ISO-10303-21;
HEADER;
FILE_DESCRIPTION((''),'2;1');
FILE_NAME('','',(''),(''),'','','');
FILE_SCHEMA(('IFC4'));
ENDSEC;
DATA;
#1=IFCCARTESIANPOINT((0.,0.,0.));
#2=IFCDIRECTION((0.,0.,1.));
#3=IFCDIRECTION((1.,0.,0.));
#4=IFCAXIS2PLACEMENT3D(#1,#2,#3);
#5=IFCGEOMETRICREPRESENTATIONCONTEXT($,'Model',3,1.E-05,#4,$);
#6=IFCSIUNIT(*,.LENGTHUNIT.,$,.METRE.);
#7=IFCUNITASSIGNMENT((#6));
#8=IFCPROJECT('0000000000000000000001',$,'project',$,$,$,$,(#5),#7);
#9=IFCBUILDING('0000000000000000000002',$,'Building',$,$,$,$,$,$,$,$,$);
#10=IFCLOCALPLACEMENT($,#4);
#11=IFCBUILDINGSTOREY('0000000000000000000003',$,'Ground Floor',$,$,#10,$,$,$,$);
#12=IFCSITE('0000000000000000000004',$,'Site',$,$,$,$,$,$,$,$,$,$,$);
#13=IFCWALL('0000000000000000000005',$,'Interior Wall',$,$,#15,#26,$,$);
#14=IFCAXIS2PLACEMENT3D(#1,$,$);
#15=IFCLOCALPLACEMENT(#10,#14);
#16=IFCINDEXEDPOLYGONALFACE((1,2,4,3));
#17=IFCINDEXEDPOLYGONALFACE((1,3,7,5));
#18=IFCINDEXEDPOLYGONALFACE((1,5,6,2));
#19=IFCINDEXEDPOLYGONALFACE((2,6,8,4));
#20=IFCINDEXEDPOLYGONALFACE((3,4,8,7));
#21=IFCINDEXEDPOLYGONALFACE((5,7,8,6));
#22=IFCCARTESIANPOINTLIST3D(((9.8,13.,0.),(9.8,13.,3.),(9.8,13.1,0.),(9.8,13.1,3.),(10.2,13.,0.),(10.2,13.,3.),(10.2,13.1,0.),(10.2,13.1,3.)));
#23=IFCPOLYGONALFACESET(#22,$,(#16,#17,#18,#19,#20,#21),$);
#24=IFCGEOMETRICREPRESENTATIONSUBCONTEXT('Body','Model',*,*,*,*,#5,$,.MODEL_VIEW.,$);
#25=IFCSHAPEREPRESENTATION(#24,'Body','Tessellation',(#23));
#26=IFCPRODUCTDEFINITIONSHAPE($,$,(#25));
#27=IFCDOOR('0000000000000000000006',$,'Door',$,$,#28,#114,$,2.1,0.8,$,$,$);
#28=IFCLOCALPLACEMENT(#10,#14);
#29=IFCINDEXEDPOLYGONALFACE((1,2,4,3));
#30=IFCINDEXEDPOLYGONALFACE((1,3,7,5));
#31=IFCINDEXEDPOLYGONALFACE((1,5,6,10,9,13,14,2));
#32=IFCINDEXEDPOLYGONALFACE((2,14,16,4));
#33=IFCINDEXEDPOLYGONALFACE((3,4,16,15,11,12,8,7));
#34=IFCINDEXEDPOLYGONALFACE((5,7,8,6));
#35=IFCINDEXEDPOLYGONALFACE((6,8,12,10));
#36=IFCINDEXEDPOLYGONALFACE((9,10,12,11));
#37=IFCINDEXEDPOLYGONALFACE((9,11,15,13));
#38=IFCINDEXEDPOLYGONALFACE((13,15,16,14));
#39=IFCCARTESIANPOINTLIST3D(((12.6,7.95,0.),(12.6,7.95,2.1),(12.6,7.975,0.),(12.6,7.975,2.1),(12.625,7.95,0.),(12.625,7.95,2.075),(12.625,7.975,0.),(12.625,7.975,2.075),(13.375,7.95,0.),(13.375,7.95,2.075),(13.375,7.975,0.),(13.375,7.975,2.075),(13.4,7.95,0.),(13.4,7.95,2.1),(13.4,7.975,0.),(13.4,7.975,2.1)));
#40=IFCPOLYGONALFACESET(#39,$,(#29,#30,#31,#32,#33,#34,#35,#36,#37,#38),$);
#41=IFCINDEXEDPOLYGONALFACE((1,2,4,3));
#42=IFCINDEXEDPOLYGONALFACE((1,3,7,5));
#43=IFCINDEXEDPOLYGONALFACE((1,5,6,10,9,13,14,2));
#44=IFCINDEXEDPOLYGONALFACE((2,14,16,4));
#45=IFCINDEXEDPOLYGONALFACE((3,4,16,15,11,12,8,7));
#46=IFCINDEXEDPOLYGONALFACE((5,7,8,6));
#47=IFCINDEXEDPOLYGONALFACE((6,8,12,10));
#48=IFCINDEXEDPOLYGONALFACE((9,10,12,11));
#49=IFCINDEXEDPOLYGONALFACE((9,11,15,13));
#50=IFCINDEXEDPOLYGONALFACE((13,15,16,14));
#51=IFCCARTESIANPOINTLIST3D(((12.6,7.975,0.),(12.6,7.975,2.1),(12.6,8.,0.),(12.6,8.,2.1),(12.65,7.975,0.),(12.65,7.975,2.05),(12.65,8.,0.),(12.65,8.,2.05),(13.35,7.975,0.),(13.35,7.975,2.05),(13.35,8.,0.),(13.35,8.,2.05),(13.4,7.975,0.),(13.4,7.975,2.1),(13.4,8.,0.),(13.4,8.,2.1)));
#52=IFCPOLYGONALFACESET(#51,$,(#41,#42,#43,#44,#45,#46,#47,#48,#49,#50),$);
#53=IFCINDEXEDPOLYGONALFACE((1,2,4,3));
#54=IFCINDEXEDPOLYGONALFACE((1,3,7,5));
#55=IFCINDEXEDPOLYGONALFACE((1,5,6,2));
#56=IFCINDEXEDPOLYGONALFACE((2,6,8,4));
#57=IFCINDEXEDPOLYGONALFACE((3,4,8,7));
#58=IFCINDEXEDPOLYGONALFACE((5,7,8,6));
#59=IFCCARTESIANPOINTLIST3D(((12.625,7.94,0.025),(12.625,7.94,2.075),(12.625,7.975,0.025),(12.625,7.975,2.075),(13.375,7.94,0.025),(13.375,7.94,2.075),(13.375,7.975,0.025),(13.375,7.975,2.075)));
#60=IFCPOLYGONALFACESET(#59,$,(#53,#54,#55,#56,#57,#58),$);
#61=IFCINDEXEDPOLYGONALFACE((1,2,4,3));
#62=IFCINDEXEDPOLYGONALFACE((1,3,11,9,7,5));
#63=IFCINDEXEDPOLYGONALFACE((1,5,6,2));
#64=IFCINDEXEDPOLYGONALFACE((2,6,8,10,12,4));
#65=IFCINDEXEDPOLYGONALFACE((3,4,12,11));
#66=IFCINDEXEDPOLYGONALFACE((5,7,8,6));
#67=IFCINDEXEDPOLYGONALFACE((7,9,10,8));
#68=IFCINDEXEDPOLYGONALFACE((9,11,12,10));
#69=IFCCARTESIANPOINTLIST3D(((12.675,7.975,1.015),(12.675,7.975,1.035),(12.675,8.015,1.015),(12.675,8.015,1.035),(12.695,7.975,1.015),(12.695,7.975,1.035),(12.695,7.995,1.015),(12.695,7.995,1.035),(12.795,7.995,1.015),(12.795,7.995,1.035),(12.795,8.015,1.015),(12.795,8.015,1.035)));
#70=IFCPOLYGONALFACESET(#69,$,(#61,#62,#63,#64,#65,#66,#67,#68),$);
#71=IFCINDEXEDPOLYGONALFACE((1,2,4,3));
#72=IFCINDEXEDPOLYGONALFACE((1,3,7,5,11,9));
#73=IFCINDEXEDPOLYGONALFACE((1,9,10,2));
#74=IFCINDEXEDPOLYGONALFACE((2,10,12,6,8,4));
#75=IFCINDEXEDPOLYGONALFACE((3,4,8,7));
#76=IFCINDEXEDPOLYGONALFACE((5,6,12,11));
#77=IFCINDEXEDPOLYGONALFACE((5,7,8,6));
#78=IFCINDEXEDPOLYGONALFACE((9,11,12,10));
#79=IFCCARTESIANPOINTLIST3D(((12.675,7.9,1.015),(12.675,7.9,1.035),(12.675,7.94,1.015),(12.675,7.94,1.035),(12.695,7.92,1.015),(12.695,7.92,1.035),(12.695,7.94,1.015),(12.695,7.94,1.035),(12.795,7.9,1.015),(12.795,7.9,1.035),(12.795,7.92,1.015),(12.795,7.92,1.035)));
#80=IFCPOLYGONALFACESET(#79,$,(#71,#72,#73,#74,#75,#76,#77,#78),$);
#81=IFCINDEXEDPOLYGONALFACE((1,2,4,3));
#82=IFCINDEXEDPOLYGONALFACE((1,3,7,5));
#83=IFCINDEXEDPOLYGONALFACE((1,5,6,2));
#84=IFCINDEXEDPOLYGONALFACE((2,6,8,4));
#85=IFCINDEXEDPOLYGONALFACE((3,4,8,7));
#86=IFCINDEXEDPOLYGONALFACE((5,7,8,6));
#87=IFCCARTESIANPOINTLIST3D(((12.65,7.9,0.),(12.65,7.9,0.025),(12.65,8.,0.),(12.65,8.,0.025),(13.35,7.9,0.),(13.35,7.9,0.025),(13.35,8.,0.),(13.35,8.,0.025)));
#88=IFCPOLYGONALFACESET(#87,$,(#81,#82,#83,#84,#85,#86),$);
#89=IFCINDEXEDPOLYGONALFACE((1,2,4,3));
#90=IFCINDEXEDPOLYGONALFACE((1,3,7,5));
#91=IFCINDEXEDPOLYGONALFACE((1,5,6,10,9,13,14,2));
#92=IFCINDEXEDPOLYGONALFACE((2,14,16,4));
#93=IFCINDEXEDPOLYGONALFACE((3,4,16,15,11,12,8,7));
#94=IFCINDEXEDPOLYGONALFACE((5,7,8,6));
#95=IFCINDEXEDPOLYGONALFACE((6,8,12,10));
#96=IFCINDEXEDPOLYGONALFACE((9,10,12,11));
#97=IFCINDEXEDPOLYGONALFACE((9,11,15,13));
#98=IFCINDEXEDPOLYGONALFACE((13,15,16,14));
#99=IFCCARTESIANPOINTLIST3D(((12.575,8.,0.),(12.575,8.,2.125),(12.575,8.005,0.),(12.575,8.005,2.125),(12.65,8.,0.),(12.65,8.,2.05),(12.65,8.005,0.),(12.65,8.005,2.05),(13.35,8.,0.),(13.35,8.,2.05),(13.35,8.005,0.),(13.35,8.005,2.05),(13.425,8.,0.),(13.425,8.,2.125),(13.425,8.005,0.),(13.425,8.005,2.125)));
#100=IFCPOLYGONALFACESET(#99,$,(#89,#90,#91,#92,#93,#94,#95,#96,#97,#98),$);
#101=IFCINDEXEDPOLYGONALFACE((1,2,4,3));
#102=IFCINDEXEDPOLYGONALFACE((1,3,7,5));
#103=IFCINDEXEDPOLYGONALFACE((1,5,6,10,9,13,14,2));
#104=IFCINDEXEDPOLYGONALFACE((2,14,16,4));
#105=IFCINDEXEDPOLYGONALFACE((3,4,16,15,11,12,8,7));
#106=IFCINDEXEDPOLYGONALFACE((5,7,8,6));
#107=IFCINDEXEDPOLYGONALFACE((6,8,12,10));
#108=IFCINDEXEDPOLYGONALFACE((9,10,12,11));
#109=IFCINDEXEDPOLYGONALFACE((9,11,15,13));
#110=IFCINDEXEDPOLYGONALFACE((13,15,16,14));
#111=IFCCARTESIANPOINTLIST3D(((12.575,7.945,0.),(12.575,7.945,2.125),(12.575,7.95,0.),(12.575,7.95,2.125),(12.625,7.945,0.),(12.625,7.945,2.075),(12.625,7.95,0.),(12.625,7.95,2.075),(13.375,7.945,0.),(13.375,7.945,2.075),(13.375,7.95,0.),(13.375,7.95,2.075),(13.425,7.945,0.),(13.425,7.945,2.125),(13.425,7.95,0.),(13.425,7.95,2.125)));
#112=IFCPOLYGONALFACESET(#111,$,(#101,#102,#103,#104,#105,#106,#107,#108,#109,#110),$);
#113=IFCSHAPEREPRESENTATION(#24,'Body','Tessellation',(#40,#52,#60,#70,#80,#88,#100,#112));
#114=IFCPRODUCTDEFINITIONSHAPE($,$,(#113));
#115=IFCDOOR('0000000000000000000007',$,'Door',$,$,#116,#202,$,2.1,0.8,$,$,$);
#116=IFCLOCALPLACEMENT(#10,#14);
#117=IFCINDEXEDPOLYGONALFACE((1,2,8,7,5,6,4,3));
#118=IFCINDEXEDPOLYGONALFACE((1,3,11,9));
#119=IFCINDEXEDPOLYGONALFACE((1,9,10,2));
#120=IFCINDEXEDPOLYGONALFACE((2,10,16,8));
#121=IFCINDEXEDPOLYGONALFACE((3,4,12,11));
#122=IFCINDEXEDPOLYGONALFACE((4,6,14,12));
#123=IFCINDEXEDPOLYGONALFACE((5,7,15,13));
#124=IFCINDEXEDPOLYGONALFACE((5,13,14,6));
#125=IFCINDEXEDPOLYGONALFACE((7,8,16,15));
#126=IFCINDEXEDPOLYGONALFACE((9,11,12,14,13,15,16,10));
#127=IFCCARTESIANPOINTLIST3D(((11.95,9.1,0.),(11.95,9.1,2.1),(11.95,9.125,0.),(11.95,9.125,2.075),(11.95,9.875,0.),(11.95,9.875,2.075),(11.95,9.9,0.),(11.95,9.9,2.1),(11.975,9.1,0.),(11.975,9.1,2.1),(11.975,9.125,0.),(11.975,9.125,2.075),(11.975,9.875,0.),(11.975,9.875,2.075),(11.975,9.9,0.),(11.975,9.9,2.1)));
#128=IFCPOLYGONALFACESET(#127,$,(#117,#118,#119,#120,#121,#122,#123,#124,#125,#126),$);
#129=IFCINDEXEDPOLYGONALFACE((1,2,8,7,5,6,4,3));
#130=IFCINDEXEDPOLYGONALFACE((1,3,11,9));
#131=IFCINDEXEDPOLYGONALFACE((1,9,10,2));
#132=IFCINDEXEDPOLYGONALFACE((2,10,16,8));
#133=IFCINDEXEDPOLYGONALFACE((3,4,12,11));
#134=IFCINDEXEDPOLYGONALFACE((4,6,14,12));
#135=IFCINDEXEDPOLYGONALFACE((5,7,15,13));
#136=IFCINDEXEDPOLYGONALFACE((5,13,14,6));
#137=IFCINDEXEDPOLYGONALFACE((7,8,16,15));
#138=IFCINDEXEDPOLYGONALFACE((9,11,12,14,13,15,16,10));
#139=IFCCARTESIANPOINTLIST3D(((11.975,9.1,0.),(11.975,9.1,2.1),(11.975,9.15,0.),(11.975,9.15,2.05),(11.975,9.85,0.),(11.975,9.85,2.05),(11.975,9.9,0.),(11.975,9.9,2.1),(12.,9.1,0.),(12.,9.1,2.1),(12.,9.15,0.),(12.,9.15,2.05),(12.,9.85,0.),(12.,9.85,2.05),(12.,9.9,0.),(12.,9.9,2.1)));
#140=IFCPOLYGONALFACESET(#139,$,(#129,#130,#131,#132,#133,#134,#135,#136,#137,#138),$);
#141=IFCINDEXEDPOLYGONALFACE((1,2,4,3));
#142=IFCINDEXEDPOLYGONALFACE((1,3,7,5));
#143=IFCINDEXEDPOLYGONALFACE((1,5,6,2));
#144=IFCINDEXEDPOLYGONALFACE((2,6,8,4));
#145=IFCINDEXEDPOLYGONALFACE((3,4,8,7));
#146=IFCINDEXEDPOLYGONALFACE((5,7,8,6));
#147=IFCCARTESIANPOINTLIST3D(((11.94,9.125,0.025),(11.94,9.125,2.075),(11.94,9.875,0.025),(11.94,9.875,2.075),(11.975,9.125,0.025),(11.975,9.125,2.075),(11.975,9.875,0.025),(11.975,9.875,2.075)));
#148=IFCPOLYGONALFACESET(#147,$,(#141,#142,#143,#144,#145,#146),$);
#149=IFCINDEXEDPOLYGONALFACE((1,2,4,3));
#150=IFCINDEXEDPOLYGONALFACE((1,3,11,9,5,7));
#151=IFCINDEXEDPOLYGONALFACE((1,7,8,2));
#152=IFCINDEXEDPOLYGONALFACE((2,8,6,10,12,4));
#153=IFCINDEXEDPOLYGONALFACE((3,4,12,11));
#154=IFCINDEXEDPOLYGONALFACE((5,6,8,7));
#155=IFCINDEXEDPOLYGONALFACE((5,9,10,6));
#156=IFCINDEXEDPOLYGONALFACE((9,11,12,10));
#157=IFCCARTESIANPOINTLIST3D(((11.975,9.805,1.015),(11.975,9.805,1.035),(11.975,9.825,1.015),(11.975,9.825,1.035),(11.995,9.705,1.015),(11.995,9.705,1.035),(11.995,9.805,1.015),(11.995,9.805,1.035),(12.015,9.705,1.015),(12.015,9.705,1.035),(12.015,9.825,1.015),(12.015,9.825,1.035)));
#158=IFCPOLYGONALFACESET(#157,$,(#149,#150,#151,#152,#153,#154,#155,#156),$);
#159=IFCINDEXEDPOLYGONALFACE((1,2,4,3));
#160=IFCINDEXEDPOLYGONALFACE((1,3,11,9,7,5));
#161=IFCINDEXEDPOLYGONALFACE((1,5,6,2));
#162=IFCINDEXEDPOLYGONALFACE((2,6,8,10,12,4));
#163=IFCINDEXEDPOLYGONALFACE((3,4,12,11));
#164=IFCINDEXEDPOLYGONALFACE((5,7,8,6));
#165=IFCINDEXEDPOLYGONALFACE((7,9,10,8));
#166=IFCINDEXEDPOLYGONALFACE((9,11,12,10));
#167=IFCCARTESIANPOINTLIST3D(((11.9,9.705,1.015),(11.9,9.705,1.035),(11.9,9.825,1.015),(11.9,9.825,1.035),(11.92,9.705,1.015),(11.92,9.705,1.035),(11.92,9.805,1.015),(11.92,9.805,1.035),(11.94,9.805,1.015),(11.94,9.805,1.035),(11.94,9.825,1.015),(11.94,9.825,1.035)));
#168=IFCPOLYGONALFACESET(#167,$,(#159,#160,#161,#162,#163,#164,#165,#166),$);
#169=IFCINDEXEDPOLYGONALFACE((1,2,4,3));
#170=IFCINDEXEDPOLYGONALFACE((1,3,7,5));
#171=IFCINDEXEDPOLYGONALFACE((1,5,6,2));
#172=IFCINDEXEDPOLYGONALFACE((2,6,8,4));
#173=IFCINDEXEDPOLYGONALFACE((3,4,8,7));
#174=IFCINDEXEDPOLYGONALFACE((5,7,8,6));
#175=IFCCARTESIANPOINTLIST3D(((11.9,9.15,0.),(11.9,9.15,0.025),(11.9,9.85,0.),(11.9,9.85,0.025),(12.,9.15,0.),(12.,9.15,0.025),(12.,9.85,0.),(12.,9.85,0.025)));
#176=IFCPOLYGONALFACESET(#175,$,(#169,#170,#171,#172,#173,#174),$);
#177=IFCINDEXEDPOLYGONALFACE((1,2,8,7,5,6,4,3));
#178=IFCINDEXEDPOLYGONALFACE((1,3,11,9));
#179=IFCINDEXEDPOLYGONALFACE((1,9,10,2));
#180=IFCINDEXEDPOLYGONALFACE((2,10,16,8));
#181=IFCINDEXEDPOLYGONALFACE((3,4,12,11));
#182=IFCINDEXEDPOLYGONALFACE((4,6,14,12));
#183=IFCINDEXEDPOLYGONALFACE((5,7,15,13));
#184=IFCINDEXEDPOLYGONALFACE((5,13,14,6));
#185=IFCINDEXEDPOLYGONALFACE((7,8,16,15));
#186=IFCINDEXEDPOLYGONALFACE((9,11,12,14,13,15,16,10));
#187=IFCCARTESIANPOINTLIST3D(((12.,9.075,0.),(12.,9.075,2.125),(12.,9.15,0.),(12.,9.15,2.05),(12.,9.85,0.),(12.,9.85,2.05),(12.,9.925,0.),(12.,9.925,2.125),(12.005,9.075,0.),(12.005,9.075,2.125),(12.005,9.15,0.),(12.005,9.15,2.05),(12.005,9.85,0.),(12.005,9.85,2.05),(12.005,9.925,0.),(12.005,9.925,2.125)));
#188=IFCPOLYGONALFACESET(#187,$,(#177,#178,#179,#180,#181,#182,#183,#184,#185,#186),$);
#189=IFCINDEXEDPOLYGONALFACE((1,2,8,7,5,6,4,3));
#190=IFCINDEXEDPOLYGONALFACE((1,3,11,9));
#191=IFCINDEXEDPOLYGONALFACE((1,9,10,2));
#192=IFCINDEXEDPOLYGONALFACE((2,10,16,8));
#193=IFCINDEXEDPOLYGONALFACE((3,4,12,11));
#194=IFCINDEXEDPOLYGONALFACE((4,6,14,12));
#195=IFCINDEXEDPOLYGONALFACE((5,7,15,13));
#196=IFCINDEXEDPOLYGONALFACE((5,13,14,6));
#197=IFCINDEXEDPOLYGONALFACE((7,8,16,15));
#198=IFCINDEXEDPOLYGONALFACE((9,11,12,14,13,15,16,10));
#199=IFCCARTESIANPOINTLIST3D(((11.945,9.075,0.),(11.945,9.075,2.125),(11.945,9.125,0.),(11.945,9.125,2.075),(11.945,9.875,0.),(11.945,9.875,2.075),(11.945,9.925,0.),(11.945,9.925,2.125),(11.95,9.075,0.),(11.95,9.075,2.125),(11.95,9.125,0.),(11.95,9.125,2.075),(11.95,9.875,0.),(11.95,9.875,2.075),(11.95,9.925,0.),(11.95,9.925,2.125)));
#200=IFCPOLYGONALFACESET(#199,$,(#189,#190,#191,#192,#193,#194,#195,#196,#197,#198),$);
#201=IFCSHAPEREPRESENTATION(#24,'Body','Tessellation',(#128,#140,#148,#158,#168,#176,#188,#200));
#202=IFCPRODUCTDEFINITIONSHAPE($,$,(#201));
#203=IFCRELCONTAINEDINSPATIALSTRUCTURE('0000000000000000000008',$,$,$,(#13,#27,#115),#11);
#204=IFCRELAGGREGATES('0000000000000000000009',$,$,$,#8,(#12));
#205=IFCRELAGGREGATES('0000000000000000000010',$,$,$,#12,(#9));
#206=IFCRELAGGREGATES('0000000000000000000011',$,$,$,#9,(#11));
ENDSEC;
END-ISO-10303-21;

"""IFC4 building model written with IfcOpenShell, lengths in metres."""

from ifc_helpers import new_model, si_unit, frame, origin_with_axes, place, context, subcontext, project, spatial, line, indexed_curve, outline, extrude, element, save


model = new_model("IFC4")

# Units and contexts
model_context = context("Model", 3, precision=1e-05, world=origin_with_axes())
body_context = subcontext(model_context, "Body", "Model", "MODEL_VIEW")
ifc_project = project(units=[si_unit("LENGTHUNIT", "METRE")], contexts=[model_context])

# Site, building, storey
site = spatial("IfcSite", under=ifc_project, Name="Site")
building = spatial("IfcBuilding", under=site, Name="Building")
storey_placement = place(None, origin_with_axes())
storey = spatial("IfcBuildingStorey", under=building, at=storey_placement, Name="Ground Floor")

# Wall
for number, where, z_axis, x_axis, name in (
    (1, (10.0, 13.1, 0.0), (0.0, 0.0, 1.0), (0.0, -1.0, 0.0), "Interior Wall"),
):
    element("IfcWall", number, at=place(storey_placement, frame(where, z_axis=z_axis, x_axis=x_axis)), inside=storey, Name=name, context=body_context, shape_type="SweptSolid", body=[
        extrude(outline(indexed_curve([(0.0, 0.0), (0.0, 0.4), (0.1, 0.4), (0.1, 0.0), (0.0, 0.0)], self_intersect=False)), frame((0.0, -0.2, 0.0), z_axis=(0.0, 0.0, 1.0), x_axis=(1.0, 0.0, 0.0)), (0.0, 0.0, 1.0), 3.0),
    ])

# Doors
door_1_placement = place(storey_placement, frame((13.4, 8.0, 0.0), z_axis=(0.0, 0.0, 1.0), x_axis=(-1.0, 0.0, 0.0)))
element("IfcDoor", 2, at=door_1_placement, inside=storey, Name="Door", OverallHeight=2.1, OverallWidth=0.8, context=body_context, shape_type="SweptSolid", body=[
    extrude(outline(indexed_curve([(0.0, 0.0), (0.0, 2.1), (0.8, 2.1), (0.8, 0.0), (0.775, 0.0), (0.775, 2.075), (0.025, 2.075), (0.025, 0.0)], segments=[line(1, 2, 3, 4, 5, 6, 7, 8, 1)])), frame((0.0, 0.025, 0.0), z_axis=(0.0, -1.0, 0.0), x_axis=(1.0, 0.0, 0.0)), (0.0, 0.0, -1.0), 0.025),
    extrude(outline(indexed_curve([(0.0, 0.0), (0.0, 2.1), (0.8, 2.1), (0.8, 0.0), (0.75, 0.0), (0.75, 2.05), (0.05, 2.05), (0.05, 0.0)], segments=[line(1, 2, 3, 4, 5, 6, 7, 8, 1)])), frame((0.0, 0.0, 0.0), z_axis=(0.0, -1.0, 0.0), x_axis=(1.0, 0.0, 0.0)), (0.0, 0.0, -1.0), 0.025),
    extrude(outline(indexed_curve([(0.0, 0.0), (0.75, 0.0), (0.75, 0.035), (0.0, 0.035)], segments=[line(1, 2, 3, 4, 1)])), frame((0.025, 0.025, 0.025), z_axis=(0.0, 0.0, 1.0), x_axis=(1.0, 0.0, 0.0)), (0.0, 0.0, 1.0), 2.05),
    extrude(outline(indexed_curve([(0.0, 0.0), (0.0, -0.04), (-0.12, -0.04), (-0.12, -0.02), (-0.02, -0.02), (-0.02, 0.0)], segments=[line(1, 2, 3, 4, 5, 6, 1)])), frame((0.725, 0.025, 1.015), z_axis=(0.0, 0.0, 1.0), x_axis=(1.0, 0.0, 0.0)), (0.0, 0.0, 1.0), 0.02),
    extrude(outline(indexed_curve([(0.0, 0.0), (0.0, 0.04), (-0.12, 0.04), (-0.12, 0.02), (-0.02, 0.02), (-0.02, 0.0)], segments=[line(1, 2, 3, 4, 5, 6, 1)])), frame((0.725, 0.06, 1.015), z_axis=(0.0, 0.0, 1.0), x_axis=(1.0, 0.0, 0.0)), (0.0, 0.0, 1.0), 0.02),
    extrude(outline(indexed_curve([(0.0, 0.0), (0.7, 0.0), (0.7, 0.1), (0.0, 0.1)], segments=[line(1, 2, 3, 4, 1)])), frame((0.05, 0.0, 0.0), z_axis=(0.0, 0.0, 1.0), x_axis=(1.0, 0.0, 0.0)), (0.0, 0.0, 1.0), 0.025),
    extrude(outline(indexed_curve([(0.0, 0.0), (0.0, 2.125), (0.85, 2.125), (0.85, 0.0), (0.775, 0.0), (0.775, 2.05), (0.075, 2.05), (0.075, 0.0)], segments=[line(1, 2, 3, 4, 5, 6, 7, 8, 1)])), frame((-0.025, -0.005, 0.0), z_axis=(0.0, -1.0, 0.0), x_axis=(1.0, 0.0, 0.0)), (0.0, 0.0, -1.0), 0.005),
    extrude(outline(indexed_curve([(0.0, 0.0), (0.0, 2.125), (0.85, 2.125), (0.85, 0.0), (0.8, 0.0), (0.8, 2.075), (0.05, 2.075), (0.05, 0.0)], segments=[line(1, 2, 3, 4, 5, 6, 7, 8, 1)])), frame((-0.025, 0.05, 0.0), z_axis=(0.0, -1.0, 0.0), x_axis=(1.0, 0.0, 0.0)), (0.0, 0.0, -1.0), 0.005),
])
door_2_placement = place(storey_placement, frame((12.0, 9.1, 0.0), z_axis=(0.0, 0.0, 1.0), x_axis=(0.0, 1.0, 0.0)))
element("IfcDoor", 3, at=door_2_placement, inside=storey, Name="Door", OverallHeight=2.1, OverallWidth=0.8, context=body_context, shape_type="SweptSolid", body=[
    extrude(outline(indexed_curve([(0.0, 0.0), (0.0, 2.1), (0.8, 2.1), (0.8, 0.0), (0.775, 0.0), (0.775, 2.075), (0.025, 2.075), (0.025, 0.0)], segments=[line(1, 2, 3, 4, 5, 6, 7, 8, 1)])), frame((0.0, 0.025, 0.0), z_axis=(0.0, -1.0, 0.0), x_axis=(1.0, 0.0, 0.0)), (0.0, 0.0, -1.0), 0.025),
    extrude(outline(indexed_curve([(0.0, 0.0), (0.0, 2.1), (0.8, 2.1), (0.8, 0.0), (0.75, 0.0), (0.75, 2.05), (0.05, 2.05), (0.05, 0.0)], segments=[line(1, 2, 3, 4, 5, 6, 7, 8, 1)])), frame((0.0, 0.0, 0.0), z_axis=(0.0, -1.0, 0.0), x_axis=(1.0, 0.0, 0.0)), (0.0, 0.0, -1.0), 0.025),
    extrude(outline(indexed_curve([(0.0, 0.0), (0.75, 0.0), (0.75, 0.035), (0.0, 0.035)], segments=[line(1, 2, 3, 4, 1)])), frame((0.025, 0.025, 0.025), z_axis=(0.0, 0.0, 1.0), x_axis=(1.0, 0.0, 0.0)), (0.0, 0.0, 1.0), 2.05),
    extrude(outline(indexed_curve([(0.0, 0.0), (0.0, -0.04), (-0.12, -0.04), (-0.12, -0.02), (-0.02, -0.02), (-0.02, 0.0)], segments=[line(1, 2, 3, 4, 5, 6, 1)])), frame((0.725, 0.025, 1.015), z_axis=(0.0, 0.0, 1.0), x_axis=(1.0, 0.0, 0.0)), (0.0, 0.0, 1.0), 0.02),
    extrude(outline(indexed_curve([(0.0, 0.0), (0.0, 0.04), (-0.12, 0.04), (-0.12, 0.02), (-0.02, 0.02), (-0.02, 0.0)], segments=[line(1, 2, 3, 4, 5, 6, 1)])), frame((0.725, 0.06, 1.015), z_axis=(0.0, 0.0, 1.0), x_axis=(1.0, 0.0, 0.0)), (0.0, 0.0, 1.0), 0.02),
    extrude(outline(indexed_curve([(0.0, 0.0), (0.7, 0.0), (0.7, 0.1), (0.0, 0.1)], segments=[line(1, 2, 3, 4, 1)])), frame((0.05, 0.0, 0.0), z_axis=(0.0, 0.0, 1.0), x_axis=(1.0, 0.0, 0.0)), (0.0, 0.0, 1.0), 0.025),
    extrude(outline(indexed_curve([(0.0, 0.0), (0.0, 2.125), (0.85, 2.125), (0.85, 0.0), (0.775, 0.0), (0.775, 2.05), (0.075, 2.05), (0.075, 0.0)], segments=[line(1, 2, 3, 4, 5, 6, 7, 8, 1)])), frame((-0.025, -0.005, 0.0), z_axis=(0.0, -1.0, 0.0), x_axis=(1.0, 0.0, 0.0)), (0.0, 0.0, -1.0), 0.005),
    extrude(outline(indexed_curve([(0.0, 0.0), (0.0, 2.125), (0.85, 2.125), (0.85, 0.0), (0.8, 0.0), (0.8, 2.075), (0.05, 2.075), (0.05, 0.0)], segments=[line(1, 2, 3, 4, 5, 6, 7, 8, 1)])), frame((-0.025, 0.05, 0.0), z_axis=(0.0, -1.0, 0.0), x_axis=(1.0, 0.0, 0.0)), (0.0, 0.0, -1.0), 0.005),
])

save(model, "model.ifc")
